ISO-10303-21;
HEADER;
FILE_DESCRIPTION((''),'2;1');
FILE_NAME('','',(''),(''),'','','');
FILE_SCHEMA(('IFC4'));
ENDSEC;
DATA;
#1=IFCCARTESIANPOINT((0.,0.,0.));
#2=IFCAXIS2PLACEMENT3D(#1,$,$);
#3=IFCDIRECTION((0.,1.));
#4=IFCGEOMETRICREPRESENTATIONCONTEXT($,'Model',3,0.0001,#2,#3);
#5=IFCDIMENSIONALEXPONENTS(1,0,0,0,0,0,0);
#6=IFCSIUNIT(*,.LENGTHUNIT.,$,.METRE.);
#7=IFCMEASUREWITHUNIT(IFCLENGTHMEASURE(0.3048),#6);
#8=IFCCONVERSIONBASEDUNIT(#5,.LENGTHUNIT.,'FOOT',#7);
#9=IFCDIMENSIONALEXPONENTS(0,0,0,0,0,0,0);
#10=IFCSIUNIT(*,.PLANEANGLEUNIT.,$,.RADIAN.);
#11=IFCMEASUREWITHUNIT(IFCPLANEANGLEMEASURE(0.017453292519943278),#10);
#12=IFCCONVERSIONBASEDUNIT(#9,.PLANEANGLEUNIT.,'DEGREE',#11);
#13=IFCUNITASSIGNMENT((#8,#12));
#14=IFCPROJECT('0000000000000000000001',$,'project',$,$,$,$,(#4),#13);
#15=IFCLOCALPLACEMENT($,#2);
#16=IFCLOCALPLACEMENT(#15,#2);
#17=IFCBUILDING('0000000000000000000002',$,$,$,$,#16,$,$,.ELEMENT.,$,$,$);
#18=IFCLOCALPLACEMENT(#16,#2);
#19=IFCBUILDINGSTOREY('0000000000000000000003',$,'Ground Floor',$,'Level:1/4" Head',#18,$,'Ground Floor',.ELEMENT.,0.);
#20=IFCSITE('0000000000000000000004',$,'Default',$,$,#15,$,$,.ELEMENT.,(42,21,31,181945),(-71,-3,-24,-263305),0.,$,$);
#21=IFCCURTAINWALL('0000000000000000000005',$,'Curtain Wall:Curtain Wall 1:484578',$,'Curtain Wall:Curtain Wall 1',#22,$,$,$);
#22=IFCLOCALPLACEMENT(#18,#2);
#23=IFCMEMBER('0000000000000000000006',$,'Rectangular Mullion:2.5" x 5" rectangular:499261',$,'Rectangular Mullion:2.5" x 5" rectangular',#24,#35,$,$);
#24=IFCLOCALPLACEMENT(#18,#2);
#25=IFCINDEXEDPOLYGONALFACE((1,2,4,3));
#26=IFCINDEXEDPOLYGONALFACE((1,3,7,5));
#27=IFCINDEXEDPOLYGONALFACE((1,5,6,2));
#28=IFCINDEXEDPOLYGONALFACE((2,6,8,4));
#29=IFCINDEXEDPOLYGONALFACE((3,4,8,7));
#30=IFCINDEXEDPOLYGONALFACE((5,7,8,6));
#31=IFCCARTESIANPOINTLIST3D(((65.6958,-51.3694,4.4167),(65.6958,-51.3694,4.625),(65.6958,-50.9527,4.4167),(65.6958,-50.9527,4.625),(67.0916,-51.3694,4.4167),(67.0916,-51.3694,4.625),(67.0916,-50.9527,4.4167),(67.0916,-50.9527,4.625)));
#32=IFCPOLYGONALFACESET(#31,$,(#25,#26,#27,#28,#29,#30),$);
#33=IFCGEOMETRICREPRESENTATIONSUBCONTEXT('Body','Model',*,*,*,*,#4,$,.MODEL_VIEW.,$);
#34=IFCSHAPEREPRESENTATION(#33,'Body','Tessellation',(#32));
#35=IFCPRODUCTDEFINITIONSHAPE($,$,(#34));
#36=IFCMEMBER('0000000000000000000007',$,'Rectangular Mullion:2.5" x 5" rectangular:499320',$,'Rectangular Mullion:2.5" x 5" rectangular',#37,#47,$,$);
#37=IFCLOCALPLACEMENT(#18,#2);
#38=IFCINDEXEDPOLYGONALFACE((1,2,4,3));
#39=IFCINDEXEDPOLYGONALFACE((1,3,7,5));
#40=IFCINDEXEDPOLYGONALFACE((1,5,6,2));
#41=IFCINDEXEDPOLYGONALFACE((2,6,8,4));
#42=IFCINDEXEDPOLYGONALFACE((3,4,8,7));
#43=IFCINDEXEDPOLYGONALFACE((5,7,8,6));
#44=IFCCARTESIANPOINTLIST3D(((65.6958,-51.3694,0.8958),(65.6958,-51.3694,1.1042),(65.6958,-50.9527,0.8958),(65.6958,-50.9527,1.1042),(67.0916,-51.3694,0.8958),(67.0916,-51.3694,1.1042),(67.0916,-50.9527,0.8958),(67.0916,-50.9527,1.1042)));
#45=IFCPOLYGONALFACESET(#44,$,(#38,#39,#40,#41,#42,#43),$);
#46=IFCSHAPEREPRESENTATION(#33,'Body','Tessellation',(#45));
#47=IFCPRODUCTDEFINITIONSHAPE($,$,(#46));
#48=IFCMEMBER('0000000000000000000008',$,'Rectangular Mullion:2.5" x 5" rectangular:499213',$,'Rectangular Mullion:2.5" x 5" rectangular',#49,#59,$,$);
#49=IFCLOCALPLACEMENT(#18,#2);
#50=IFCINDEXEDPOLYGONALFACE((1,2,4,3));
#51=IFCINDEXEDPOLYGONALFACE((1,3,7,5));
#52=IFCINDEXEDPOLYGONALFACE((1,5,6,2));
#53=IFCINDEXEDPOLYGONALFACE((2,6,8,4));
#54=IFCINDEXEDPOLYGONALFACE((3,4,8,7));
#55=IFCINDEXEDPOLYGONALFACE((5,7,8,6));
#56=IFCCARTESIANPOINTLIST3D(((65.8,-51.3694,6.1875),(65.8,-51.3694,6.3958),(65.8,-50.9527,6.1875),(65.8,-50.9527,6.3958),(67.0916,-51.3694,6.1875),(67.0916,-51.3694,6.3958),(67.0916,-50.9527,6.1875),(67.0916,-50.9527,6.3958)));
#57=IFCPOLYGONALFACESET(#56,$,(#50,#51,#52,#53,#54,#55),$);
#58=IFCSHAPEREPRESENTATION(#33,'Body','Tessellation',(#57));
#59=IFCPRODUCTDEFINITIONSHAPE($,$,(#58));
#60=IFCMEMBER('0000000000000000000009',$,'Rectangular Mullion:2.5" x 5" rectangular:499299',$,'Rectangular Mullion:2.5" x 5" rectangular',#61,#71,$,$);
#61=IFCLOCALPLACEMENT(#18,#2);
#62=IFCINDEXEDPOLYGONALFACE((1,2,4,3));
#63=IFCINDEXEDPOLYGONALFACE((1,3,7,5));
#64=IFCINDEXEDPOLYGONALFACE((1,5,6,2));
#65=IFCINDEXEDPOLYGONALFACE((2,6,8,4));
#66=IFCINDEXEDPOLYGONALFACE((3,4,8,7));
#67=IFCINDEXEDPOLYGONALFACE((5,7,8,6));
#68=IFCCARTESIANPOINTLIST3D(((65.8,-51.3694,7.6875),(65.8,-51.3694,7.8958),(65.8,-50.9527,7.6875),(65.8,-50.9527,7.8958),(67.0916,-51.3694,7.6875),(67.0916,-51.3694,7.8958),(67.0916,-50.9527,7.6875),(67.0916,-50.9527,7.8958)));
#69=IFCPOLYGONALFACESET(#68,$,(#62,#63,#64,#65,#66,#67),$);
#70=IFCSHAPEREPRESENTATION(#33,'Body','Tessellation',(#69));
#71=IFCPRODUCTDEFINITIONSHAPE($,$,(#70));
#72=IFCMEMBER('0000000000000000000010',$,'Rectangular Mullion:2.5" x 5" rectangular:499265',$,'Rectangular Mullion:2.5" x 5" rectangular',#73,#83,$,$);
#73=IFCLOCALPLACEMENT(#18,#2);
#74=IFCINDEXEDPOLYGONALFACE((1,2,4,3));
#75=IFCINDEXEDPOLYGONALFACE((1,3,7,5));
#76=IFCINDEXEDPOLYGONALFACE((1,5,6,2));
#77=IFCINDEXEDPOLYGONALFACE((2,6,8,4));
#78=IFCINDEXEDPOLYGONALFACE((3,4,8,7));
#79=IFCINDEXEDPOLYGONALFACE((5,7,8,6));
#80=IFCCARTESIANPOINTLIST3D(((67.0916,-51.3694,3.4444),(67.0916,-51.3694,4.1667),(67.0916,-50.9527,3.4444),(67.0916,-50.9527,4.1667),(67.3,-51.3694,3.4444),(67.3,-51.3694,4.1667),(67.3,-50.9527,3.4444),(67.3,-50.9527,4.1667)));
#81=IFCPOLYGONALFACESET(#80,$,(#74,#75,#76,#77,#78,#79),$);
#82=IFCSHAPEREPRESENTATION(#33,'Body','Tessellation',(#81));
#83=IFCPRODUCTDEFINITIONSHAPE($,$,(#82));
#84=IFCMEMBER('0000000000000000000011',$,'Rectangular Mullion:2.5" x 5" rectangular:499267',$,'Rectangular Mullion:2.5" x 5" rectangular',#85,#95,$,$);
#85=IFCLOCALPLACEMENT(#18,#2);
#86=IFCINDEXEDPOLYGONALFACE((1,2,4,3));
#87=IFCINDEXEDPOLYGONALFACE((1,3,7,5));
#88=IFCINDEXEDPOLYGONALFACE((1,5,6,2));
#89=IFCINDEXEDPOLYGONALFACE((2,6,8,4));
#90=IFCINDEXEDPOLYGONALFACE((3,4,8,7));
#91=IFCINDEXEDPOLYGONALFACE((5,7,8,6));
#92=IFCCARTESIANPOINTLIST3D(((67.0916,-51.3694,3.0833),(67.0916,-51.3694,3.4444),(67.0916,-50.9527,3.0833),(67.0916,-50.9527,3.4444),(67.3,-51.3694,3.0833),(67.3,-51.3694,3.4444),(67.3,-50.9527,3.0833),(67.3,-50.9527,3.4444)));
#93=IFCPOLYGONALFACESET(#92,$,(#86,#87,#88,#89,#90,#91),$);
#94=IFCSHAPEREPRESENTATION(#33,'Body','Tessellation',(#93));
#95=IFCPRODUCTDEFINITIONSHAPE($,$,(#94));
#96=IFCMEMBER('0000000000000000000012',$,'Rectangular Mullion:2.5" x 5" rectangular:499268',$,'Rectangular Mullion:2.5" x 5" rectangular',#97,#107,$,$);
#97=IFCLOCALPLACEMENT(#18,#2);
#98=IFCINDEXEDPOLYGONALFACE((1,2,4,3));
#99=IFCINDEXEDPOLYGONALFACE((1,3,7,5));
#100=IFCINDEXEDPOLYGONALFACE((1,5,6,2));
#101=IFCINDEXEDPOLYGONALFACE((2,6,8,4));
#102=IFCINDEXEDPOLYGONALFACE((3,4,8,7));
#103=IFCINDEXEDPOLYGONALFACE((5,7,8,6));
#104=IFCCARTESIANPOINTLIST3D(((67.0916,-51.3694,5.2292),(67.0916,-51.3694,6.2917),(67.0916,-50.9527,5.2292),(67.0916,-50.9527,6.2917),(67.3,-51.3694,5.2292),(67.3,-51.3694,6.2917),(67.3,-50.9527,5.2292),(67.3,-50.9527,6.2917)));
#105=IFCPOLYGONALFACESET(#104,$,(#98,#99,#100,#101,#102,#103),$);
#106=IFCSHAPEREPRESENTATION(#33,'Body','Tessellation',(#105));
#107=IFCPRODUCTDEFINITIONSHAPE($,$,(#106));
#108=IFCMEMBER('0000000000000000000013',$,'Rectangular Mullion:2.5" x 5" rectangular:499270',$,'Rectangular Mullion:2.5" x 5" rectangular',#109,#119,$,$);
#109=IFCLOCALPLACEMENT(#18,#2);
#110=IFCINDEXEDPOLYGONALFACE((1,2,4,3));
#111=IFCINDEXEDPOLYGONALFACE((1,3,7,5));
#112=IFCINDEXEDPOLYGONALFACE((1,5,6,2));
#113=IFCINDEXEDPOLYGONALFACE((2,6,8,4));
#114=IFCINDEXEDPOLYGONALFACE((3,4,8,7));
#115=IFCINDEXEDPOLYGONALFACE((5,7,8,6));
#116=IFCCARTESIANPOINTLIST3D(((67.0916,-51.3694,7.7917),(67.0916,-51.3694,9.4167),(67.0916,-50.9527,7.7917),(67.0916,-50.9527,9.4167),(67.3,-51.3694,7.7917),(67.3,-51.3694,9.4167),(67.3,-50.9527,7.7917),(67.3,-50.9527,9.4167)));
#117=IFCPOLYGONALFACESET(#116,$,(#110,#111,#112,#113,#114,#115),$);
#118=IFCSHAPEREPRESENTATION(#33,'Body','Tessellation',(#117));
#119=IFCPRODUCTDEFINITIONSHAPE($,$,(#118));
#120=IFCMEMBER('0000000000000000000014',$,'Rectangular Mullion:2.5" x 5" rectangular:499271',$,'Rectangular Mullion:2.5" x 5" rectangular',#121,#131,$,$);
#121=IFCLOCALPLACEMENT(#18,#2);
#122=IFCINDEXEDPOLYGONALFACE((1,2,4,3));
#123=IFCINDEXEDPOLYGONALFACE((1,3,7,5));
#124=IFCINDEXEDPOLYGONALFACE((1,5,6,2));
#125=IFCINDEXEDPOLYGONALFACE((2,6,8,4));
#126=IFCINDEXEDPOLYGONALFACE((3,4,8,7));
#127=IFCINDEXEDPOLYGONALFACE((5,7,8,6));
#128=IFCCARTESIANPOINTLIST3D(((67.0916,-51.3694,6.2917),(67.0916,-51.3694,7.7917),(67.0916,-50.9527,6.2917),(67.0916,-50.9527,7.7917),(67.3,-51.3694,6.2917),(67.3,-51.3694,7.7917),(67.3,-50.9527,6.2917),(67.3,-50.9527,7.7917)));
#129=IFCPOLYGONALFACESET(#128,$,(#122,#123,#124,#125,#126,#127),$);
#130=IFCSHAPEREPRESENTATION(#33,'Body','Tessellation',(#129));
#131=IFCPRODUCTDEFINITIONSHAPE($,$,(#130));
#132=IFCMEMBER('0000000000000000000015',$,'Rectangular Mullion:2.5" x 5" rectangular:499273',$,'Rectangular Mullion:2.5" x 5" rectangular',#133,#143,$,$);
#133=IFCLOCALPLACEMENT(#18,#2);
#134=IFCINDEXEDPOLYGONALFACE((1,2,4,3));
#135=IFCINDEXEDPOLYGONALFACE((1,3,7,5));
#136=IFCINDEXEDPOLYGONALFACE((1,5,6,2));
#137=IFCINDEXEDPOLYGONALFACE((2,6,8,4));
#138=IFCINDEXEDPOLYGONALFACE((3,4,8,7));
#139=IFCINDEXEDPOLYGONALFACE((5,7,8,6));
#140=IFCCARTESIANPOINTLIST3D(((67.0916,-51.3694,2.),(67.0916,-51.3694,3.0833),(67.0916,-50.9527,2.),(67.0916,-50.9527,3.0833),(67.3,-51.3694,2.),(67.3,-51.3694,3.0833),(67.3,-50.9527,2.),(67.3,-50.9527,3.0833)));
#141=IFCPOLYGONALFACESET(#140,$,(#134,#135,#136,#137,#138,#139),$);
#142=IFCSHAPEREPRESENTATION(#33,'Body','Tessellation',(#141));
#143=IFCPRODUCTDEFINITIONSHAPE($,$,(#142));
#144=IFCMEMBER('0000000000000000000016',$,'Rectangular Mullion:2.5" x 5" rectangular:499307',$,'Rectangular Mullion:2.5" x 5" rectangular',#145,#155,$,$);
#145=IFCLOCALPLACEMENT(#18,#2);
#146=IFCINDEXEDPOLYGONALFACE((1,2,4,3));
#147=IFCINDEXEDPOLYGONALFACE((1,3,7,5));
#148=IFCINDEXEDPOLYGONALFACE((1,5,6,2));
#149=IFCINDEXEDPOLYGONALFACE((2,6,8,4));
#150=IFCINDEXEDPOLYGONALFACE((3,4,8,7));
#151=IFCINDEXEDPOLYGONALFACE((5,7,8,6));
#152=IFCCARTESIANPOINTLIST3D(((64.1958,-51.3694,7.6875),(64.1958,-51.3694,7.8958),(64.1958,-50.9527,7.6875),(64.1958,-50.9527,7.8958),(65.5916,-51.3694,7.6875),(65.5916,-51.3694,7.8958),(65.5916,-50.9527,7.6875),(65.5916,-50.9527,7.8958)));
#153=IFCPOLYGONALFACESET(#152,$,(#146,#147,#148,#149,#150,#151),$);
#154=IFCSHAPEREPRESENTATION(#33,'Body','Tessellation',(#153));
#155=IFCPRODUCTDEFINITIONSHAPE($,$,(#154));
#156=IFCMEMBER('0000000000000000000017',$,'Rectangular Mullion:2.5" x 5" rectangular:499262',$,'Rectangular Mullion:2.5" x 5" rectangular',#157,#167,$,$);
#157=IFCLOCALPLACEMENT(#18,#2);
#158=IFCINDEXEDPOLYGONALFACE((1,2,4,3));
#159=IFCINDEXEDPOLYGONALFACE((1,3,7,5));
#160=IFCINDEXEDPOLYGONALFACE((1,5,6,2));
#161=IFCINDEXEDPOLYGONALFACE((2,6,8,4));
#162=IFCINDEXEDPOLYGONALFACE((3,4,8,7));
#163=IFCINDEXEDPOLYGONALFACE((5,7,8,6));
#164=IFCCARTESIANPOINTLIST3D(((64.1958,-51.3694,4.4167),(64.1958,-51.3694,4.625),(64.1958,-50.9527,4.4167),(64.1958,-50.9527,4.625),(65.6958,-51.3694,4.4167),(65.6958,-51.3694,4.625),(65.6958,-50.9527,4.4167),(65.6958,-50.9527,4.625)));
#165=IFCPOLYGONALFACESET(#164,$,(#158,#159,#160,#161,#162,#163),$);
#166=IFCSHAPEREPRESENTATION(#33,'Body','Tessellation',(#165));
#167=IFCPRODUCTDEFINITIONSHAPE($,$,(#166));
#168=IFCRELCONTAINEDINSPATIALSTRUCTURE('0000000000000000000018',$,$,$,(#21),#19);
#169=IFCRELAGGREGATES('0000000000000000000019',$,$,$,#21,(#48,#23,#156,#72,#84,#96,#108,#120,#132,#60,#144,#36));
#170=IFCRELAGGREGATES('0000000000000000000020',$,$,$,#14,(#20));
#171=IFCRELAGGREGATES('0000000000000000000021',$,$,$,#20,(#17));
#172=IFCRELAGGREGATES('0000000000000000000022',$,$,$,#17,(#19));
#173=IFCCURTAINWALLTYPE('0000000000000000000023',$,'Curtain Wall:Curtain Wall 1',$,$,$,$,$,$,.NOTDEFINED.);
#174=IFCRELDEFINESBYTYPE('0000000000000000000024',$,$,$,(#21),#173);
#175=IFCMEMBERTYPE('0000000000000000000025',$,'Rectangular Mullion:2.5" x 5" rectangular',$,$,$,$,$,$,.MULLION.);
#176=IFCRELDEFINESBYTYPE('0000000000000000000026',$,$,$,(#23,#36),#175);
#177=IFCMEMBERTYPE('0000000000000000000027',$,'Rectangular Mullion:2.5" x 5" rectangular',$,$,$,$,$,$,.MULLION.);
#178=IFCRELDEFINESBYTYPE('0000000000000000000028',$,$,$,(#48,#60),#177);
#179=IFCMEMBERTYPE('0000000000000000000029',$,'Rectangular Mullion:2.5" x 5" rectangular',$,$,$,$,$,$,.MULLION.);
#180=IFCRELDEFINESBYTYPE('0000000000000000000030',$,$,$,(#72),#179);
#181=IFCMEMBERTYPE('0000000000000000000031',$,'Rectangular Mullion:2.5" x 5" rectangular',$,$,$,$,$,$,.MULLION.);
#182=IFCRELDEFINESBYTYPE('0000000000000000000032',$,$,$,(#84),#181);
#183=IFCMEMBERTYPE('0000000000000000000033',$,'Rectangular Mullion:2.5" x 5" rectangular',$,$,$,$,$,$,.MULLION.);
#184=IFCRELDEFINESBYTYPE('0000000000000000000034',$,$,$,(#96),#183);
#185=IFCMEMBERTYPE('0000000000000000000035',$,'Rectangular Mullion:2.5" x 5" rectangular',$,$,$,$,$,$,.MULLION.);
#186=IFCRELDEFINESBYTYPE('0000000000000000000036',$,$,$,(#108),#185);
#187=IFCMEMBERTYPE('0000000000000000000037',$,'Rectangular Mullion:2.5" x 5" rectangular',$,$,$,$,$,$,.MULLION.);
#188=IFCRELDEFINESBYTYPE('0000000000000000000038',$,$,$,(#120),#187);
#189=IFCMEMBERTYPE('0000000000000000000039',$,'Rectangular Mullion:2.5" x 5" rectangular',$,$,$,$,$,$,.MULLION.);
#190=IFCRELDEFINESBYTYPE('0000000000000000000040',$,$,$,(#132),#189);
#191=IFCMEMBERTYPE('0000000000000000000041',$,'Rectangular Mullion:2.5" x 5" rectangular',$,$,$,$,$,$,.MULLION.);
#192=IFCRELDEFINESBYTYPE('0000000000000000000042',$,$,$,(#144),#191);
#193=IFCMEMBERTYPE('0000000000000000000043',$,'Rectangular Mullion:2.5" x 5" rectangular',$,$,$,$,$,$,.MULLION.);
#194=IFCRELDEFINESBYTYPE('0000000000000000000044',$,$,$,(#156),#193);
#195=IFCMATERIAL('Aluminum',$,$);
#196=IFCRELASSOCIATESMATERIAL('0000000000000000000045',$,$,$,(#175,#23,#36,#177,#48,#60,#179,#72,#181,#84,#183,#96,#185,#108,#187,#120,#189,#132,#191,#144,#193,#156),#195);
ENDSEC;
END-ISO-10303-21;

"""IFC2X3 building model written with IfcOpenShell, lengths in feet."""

from ifc_helpers import new_model, entity, si_unit, converted_unit, direction, frame, origin, origin_2d_with_axis, place, context, subcontext, project, spatial, rectangle, extrude, source, transform, mapped, material, type_object, type_shapes, element, aggregate, save


model = new_model("IFC2X3")

# Units and contexts
model_context = context("Model", 3, precision=0.0001, world=origin(), true_north=direction((0.0, 1.0)))
body_context = subcontext(model_context, "Body", "Model", "MODEL_VIEW")
ifc_project = project(units=[converted_unit("LENGTHUNIT", "FOOT", entity("IfcLengthMeasure", 0.3048), si_unit("LENGTHUNIT", "METRE"), dimensions=[1, 0, 0, 0, 0, 0, 0]), converted_unit("PLANEANGLEUNIT", "DEGREE", entity("IfcPlaneAngleMeasure", 0.017453292519943278), si_unit("PLANEANGLEUNIT", "RADIAN"), dimensions=[0, 0, 0, 0, 0, 0, 0])], contexts=[model_context])

# Site, building, storey
site_placement = place(None, origin())
site = spatial("IfcSite", under=ifc_project, at=site_placement, Name="Default", CompositionType="ELEMENT", RefLatitude=(42, 21, 31, 181945), RefLongitude=(-71, -3, -24, -263305), RefElevation=0.0)
building_placement = place(site_placement, origin())
building = spatial("IfcBuilding", under=site, at=building_placement, CompositionType="ELEMENT")
storey_placement = place(building_placement, origin())
storey = spatial("IfcBuildingStorey", under=building, at=storey_placement, Name="Ground Floor", ObjectType="Level:1/4\" Head", LongName="Ground Floor", CompositionType="ELEMENT", Elevation=0.0)

# Curtain wall, members
curtain_wall_type = type_object("IfcCurtainWallType", Name="Curtain Wall:Curtain Wall 1", PredefinedType="NOTDEFINED")
curtain_wall_placement = place(storey_placement, origin())
curtain_wall = element("IfcCurtainWall", 1, at=curtain_wall_placement, inside=storey, type_object=curtain_wall_type, Name="Curtain Wall:Curtain Wall 1:484578", ObjectType="Curtain Wall:Curtain Wall 1")
ifc_material_1 = material(Name="Aluminum")
member_type_1 = type_object("IfcMemberType", Name="Rectangular Mullion:2.5\" x 5\" rectangular", PredefinedType="MULLION", material=ifc_material_1)
shared_shape_1 = source(origin(), body_context, "Body", "SweptSolid", [
    extrude(rectangle(XDim=0.2083, YDim=0.4167, at=origin_2d_with_axis()), frame((0.0, 0.0, -1.3958), z_axis=(0.0, 0.0, 1.0), x_axis=(-1.0, 0.0, 0.0)), (0.0, 0.0, 1.0), 1.3958),
])
type_shapes(member_type_1, [shared_shape_1])
member_1_placement = place(curtain_wall_placement, frame((67.0916, -51.161, 4.5208), z_axis=(1.0, 0.0, 0.0), x_axis=(0.0, 0.0, 1.0)))
member_1 = element("IfcMember", 2, at=member_1_placement, type_object=member_type_1, material=ifc_material_1, Name="Rectangular Mullion:2.5\" x 5\" rectangular:499261", ObjectType="Rectangular Mullion:2.5\" x 5\" rectangular", context=body_context, shape_type="MappedRepresentation", body=[
    mapped(shared_shape_1, transform((0.0, 0.0, 0.0), scale=1.0)),
])
member_2_placement = place(curtain_wall_placement, frame((67.0916, -51.161, 1.0), z_axis=(1.0, 0.0, 0.0), x_axis=(0.0, 0.0, 1.0)))
member_2 = element("IfcMember", 3, at=member_2_placement, type_object=member_type_1, material=ifc_material_1, Name="Rectangular Mullion:2.5\" x 5\" rectangular:499320", ObjectType="Rectangular Mullion:2.5\" x 5\" rectangular", context=body_context, shape_type="MappedRepresentation", body=[
    mapped(shared_shape_1, transform((0.0, 0.0, 0.0), scale=1.0)),
])
member_type_2 = type_object("IfcMemberType", Name="Rectangular Mullion:2.5\" x 5\" rectangular", PredefinedType="MULLION", material=ifc_material_1)
shared_shape_2 = source(origin(), body_context, "Body", "SweptSolid", [
    extrude(rectangle(XDim=0.2083, YDim=0.4167, at=origin_2d_with_axis()), frame((0.0, 0.0, -1.2917), z_axis=(0.0, 0.0, 1.0), x_axis=(-1.0, 0.0, 0.0)), (0.0, 0.0, 1.0), 1.2917),
])
type_shapes(member_type_2, [shared_shape_2])
member_3_placement = place(curtain_wall_placement, frame((67.0916, -51.161, 6.2917), z_axis=(1.0, 0.0, 0.0), x_axis=(0.0, 0.0, 1.0)))
member_3 = element("IfcMember", 4, at=member_3_placement, type_object=member_type_2, material=ifc_material_1, Name="Rectangular Mullion:2.5\" x 5\" rectangular:499213", ObjectType="Rectangular Mullion:2.5\" x 5\" rectangular", context=body_context, shape_type="MappedRepresentation", body=[
    mapped(shared_shape_2, transform((0.0, 0.0, 0.0), scale=1.0)),
])
member_4_placement = place(curtain_wall_placement, frame((67.0916, -51.161, 7.7917), z_axis=(1.0, 0.0, 0.0), x_axis=(0.0, 0.0, 1.0)))
member_4 = element("IfcMember", 5, at=member_4_placement, type_object=member_type_2, material=ifc_material_1, Name="Rectangular Mullion:2.5\" x 5\" rectangular:499299", ObjectType="Rectangular Mullion:2.5\" x 5\" rectangular", context=body_context, shape_type="MappedRepresentation", body=[
    mapped(shared_shape_2, transform((0.0, 0.0, 0.0), scale=1.0)),
])
member_type_3 = type_object("IfcMemberType", Name="Rectangular Mullion:2.5\" x 5\" rectangular", PredefinedType="MULLION", material=ifc_material_1)
shared_shape_3 = source(origin(), body_context, "Body", "SweptSolid", [
    extrude(rectangle(XDim=0.2083, YDim=0.4167, at=origin_2d_with_axis()), frame((0.0, 0.0, -0.7222), z_axis=(0.0, 0.0, 1.0), x_axis=(-1.0, 0.0, 0.0)), (0.0, 0.0, 1.0), 0.7222),
])
type_shapes(member_type_3, [shared_shape_3])
member_5_placement = place(curtain_wall_placement, frame((67.1958, -51.161, 3.4444), z_axis=(0.0, 0.0, -1.0), x_axis=(1.0, 0.0, 0.0)))
member_5 = element("IfcMember", 6, at=member_5_placement, type_object=member_type_3, material=ifc_material_1, Name="Rectangular Mullion:2.5\" x 5\" rectangular:499265", ObjectType="Rectangular Mullion:2.5\" x 5\" rectangular", context=body_context, shape_type="MappedRepresentation", body=[
    mapped(shared_shape_3, transform((0.0, 0.0, 0.0), scale=1.0)),
])
member_type_4 = type_object("IfcMemberType", Name="Rectangular Mullion:2.5\" x 5\" rectangular", PredefinedType="MULLION", material=ifc_material_1)
shared_shape_4 = source(origin(), body_context, "Body", "SweptSolid", [
    extrude(rectangle(XDim=0.2083, YDim=0.4167, at=origin_2d_with_axis()), frame((0.0, 0.0, -0.3611), z_axis=(0.0, 0.0, 1.0), x_axis=(-1.0, 0.0, 0.0)), (0.0, 0.0, 1.0), 0.3611),
])
type_shapes(member_type_4, [shared_shape_4])
member_6_placement = place(curtain_wall_placement, frame((67.1958, -51.161, 3.0833), z_axis=(0.0, 0.0, -1.0), x_axis=(1.0, 0.0, 0.0)))
member_6 = element("IfcMember", 7, at=member_6_placement, type_object=member_type_4, material=ifc_material_1, Name="Rectangular Mullion:2.5\" x 5\" rectangular:499267", ObjectType="Rectangular Mullion:2.5\" x 5\" rectangular", context=body_context, shape_type="MappedRepresentation", body=[
    mapped(shared_shape_4, transform((0.0, 0.0, 0.0), scale=1.0)),
])
member_type_5 = type_object("IfcMemberType", Name="Rectangular Mullion:2.5\" x 5\" rectangular", PredefinedType="MULLION", material=ifc_material_1)
shared_shape_5 = source(origin(), body_context, "Body", "SweptSolid", [
    extrude(rectangle(XDim=0.2083, YDim=0.4167, at=origin_2d_with_axis()), frame((0.0, 0.0, -1.0625), z_axis=(0.0, 0.0, 1.0), x_axis=(-1.0, 0.0, 0.0)), (0.0, 0.0, 1.0), 1.0625),
])
type_shapes(member_type_5, [shared_shape_5])
member_7_placement = place(curtain_wall_placement, frame((67.1958, -51.161, 5.2292), z_axis=(0.0, 0.0, -1.0), x_axis=(1.0, 0.0, 0.0)))
member_7 = element("IfcMember", 8, at=member_7_placement, type_object=member_type_5, material=ifc_material_1, Name="Rectangular Mullion:2.5\" x 5\" rectangular:499268", ObjectType="Rectangular Mullion:2.5\" x 5\" rectangular", context=body_context, shape_type="MappedRepresentation", body=[
    mapped(shared_shape_5, transform((0.0, 0.0, 0.0), scale=1.0)),
])
member_type_6 = type_object("IfcMemberType", Name="Rectangular Mullion:2.5\" x 5\" rectangular", PredefinedType="MULLION", material=ifc_material_1)
shared_shape_6 = source(origin(), body_context, "Body", "SweptSolid", [
    extrude(rectangle(XDim=0.2083, YDim=0.4167, at=origin_2d_with_axis()), frame((0.0, 0.0, -1.625), z_axis=(0.0, 0.0, 1.0), x_axis=(-1.0, 0.0, 0.0)), (0.0, 0.0, 1.0), 1.625),
])
type_shapes(member_type_6, [shared_shape_6])
member_8_placement = place(curtain_wall_placement, frame((67.1958, -51.161, 7.7917), z_axis=(0.0, 0.0, -1.0), x_axis=(1.0, 0.0, 0.0)))
member_8 = element("IfcMember", 9, at=member_8_placement, type_object=member_type_6, material=ifc_material_1, Name="Rectangular Mullion:2.5\" x 5\" rectangular:499270", ObjectType="Rectangular Mullion:2.5\" x 5\" rectangular", context=body_context, shape_type="MappedRepresentation", body=[
    mapped(shared_shape_6, transform((0.0, 0.0, 0.0), scale=1.0)),
])
member_type_7 = type_object("IfcMemberType", Name="Rectangular Mullion:2.5\" x 5\" rectangular", PredefinedType="MULLION", material=ifc_material_1)
shared_shape_7 = source(origin(), body_context, "Body", "SweptSolid", [
    extrude(rectangle(XDim=0.2083, YDim=0.4167, at=origin_2d_with_axis()), frame((0.0, 0.0, -1.5), z_axis=(0.0, 0.0, 1.0), x_axis=(-1.0, 0.0, 0.0)), (0.0, 0.0, 1.0), 1.5),
])
type_shapes(member_type_7, [shared_shape_7])
member_9_placement = place(curtain_wall_placement, frame((67.1958, -51.161, 6.2917), z_axis=(0.0, 0.0, -1.0), x_axis=(1.0, 0.0, 0.0)))
member_9 = element("IfcMember", 10, at=member_9_placement, type_object=member_type_7, material=ifc_material_1, Name="Rectangular Mullion:2.5\" x 5\" rectangular:499271", ObjectType="Rectangular Mullion:2.5\" x 5\" rectangular", context=body_context, shape_type="MappedRepresentation", body=[
    mapped(shared_shape_7, transform((0.0, 0.0, 0.0), scale=1.0)),
])
member_type_8 = type_object("IfcMemberType", Name="Rectangular Mullion:2.5\" x 5\" rectangular", PredefinedType="MULLION", material=ifc_material_1)
shared_shape_8 = source(origin(), body_context, "Body", "SweptSolid", [
    extrude(rectangle(XDim=0.2083, YDim=0.4167, at=origin_2d_with_axis()), frame((0.0, 0.0, -1.0833), z_axis=(0.0, 0.0, 1.0), x_axis=(-1.0, 0.0, 0.0)), (0.0, 0.0, 1.0), 1.0833),
])
type_shapes(member_type_8, [shared_shape_8])
member_10_placement = place(curtain_wall_placement, frame((67.1958, -51.161, 2.0), z_axis=(0.0, 0.0, -1.0), x_axis=(1.0, 0.0, 0.0)))
member_10 = element("IfcMember", 11, at=member_10_placement, type_object=member_type_8, material=ifc_material_1, Name="Rectangular Mullion:2.5\" x 5\" rectangular:499273", ObjectType="Rectangular Mullion:2.5\" x 5\" rectangular", context=body_context, shape_type="MappedRepresentation", body=[
    mapped(shared_shape_8, transform((0.0, 0.0, 0.0), scale=1.0)),
])
member_type_9 = type_object("IfcMemberType", Name="Rectangular Mullion:2.5\" x 5\" rectangular", PredefinedType="MULLION", material=ifc_material_1)
shared_shape_9 = source(origin(), body_context, "Body", "SweptSolid", [
    extrude(rectangle(XDim=0.2083, YDim=0.4167, at=origin_2d_with_axis()), frame((0.0, 0.0, -1.3958), z_axis=(0.0, 0.0, 1.0), x_axis=(-1.0, 0.0, 0.0)), (0.0, 0.0, 1.0), 1.3958),
])
type_shapes(member_type_9, [shared_shape_9])
member_11_placement = place(curtain_wall_placement, frame((65.5916, -51.161, 7.7917), z_axis=(1.0, 0.0, 0.0), x_axis=(0.0, 0.0, 1.0)))
member_11 = element("IfcMember", 12, at=member_11_placement, type_object=member_type_9, material=ifc_material_1, Name="Rectangular Mullion:2.5\" x 5\" rectangular:499307", ObjectType="Rectangular Mullion:2.5\" x 5\" rectangular", context=body_context, shape_type="MappedRepresentation", body=[
    mapped(shared_shape_9, transform((0.0, 0.0, 0.0), scale=1.0)),
])
member_type_10 = type_object("IfcMemberType", Name="Rectangular Mullion:2.5\" x 5\" rectangular", PredefinedType="MULLION", material=ifc_material_1)
shared_shape_10 = source(origin(), body_context, "Body", "SweptSolid", [
    extrude(rectangle(XDim=0.2083, YDim=0.4167, at=origin_2d_with_axis()), frame((0.0, 0.0, -1.5), z_axis=(0.0, 0.0, 1.0), x_axis=(-1.0, 0.0, 0.0)), (0.0, 0.0, 1.0), 1.5),
])
type_shapes(member_type_10, [shared_shape_10])
member_12_placement = place(curtain_wall_placement, frame((65.6958, -51.161, 4.5208), z_axis=(1.0, 0.0, 0.0), x_axis=(0.0, 0.0, 1.0)))
member_12 = element("IfcMember", 13, at=member_12_placement, type_object=member_type_10, material=ifc_material_1, Name="Rectangular Mullion:2.5\" x 5\" rectangular:499262", ObjectType="Rectangular Mullion:2.5\" x 5\" rectangular", context=body_context, shape_type="MappedRepresentation", body=[
    mapped(shared_shape_10, transform((0.0, 0.0, 0.0), scale=1.0)),
])
aggregate(curtain_wall, [member_3, member_1, member_12, member_5, member_6, member_7, member_8, member_9, member_10, member_4, member_11, member_2])

save(model, "model.ifc")
